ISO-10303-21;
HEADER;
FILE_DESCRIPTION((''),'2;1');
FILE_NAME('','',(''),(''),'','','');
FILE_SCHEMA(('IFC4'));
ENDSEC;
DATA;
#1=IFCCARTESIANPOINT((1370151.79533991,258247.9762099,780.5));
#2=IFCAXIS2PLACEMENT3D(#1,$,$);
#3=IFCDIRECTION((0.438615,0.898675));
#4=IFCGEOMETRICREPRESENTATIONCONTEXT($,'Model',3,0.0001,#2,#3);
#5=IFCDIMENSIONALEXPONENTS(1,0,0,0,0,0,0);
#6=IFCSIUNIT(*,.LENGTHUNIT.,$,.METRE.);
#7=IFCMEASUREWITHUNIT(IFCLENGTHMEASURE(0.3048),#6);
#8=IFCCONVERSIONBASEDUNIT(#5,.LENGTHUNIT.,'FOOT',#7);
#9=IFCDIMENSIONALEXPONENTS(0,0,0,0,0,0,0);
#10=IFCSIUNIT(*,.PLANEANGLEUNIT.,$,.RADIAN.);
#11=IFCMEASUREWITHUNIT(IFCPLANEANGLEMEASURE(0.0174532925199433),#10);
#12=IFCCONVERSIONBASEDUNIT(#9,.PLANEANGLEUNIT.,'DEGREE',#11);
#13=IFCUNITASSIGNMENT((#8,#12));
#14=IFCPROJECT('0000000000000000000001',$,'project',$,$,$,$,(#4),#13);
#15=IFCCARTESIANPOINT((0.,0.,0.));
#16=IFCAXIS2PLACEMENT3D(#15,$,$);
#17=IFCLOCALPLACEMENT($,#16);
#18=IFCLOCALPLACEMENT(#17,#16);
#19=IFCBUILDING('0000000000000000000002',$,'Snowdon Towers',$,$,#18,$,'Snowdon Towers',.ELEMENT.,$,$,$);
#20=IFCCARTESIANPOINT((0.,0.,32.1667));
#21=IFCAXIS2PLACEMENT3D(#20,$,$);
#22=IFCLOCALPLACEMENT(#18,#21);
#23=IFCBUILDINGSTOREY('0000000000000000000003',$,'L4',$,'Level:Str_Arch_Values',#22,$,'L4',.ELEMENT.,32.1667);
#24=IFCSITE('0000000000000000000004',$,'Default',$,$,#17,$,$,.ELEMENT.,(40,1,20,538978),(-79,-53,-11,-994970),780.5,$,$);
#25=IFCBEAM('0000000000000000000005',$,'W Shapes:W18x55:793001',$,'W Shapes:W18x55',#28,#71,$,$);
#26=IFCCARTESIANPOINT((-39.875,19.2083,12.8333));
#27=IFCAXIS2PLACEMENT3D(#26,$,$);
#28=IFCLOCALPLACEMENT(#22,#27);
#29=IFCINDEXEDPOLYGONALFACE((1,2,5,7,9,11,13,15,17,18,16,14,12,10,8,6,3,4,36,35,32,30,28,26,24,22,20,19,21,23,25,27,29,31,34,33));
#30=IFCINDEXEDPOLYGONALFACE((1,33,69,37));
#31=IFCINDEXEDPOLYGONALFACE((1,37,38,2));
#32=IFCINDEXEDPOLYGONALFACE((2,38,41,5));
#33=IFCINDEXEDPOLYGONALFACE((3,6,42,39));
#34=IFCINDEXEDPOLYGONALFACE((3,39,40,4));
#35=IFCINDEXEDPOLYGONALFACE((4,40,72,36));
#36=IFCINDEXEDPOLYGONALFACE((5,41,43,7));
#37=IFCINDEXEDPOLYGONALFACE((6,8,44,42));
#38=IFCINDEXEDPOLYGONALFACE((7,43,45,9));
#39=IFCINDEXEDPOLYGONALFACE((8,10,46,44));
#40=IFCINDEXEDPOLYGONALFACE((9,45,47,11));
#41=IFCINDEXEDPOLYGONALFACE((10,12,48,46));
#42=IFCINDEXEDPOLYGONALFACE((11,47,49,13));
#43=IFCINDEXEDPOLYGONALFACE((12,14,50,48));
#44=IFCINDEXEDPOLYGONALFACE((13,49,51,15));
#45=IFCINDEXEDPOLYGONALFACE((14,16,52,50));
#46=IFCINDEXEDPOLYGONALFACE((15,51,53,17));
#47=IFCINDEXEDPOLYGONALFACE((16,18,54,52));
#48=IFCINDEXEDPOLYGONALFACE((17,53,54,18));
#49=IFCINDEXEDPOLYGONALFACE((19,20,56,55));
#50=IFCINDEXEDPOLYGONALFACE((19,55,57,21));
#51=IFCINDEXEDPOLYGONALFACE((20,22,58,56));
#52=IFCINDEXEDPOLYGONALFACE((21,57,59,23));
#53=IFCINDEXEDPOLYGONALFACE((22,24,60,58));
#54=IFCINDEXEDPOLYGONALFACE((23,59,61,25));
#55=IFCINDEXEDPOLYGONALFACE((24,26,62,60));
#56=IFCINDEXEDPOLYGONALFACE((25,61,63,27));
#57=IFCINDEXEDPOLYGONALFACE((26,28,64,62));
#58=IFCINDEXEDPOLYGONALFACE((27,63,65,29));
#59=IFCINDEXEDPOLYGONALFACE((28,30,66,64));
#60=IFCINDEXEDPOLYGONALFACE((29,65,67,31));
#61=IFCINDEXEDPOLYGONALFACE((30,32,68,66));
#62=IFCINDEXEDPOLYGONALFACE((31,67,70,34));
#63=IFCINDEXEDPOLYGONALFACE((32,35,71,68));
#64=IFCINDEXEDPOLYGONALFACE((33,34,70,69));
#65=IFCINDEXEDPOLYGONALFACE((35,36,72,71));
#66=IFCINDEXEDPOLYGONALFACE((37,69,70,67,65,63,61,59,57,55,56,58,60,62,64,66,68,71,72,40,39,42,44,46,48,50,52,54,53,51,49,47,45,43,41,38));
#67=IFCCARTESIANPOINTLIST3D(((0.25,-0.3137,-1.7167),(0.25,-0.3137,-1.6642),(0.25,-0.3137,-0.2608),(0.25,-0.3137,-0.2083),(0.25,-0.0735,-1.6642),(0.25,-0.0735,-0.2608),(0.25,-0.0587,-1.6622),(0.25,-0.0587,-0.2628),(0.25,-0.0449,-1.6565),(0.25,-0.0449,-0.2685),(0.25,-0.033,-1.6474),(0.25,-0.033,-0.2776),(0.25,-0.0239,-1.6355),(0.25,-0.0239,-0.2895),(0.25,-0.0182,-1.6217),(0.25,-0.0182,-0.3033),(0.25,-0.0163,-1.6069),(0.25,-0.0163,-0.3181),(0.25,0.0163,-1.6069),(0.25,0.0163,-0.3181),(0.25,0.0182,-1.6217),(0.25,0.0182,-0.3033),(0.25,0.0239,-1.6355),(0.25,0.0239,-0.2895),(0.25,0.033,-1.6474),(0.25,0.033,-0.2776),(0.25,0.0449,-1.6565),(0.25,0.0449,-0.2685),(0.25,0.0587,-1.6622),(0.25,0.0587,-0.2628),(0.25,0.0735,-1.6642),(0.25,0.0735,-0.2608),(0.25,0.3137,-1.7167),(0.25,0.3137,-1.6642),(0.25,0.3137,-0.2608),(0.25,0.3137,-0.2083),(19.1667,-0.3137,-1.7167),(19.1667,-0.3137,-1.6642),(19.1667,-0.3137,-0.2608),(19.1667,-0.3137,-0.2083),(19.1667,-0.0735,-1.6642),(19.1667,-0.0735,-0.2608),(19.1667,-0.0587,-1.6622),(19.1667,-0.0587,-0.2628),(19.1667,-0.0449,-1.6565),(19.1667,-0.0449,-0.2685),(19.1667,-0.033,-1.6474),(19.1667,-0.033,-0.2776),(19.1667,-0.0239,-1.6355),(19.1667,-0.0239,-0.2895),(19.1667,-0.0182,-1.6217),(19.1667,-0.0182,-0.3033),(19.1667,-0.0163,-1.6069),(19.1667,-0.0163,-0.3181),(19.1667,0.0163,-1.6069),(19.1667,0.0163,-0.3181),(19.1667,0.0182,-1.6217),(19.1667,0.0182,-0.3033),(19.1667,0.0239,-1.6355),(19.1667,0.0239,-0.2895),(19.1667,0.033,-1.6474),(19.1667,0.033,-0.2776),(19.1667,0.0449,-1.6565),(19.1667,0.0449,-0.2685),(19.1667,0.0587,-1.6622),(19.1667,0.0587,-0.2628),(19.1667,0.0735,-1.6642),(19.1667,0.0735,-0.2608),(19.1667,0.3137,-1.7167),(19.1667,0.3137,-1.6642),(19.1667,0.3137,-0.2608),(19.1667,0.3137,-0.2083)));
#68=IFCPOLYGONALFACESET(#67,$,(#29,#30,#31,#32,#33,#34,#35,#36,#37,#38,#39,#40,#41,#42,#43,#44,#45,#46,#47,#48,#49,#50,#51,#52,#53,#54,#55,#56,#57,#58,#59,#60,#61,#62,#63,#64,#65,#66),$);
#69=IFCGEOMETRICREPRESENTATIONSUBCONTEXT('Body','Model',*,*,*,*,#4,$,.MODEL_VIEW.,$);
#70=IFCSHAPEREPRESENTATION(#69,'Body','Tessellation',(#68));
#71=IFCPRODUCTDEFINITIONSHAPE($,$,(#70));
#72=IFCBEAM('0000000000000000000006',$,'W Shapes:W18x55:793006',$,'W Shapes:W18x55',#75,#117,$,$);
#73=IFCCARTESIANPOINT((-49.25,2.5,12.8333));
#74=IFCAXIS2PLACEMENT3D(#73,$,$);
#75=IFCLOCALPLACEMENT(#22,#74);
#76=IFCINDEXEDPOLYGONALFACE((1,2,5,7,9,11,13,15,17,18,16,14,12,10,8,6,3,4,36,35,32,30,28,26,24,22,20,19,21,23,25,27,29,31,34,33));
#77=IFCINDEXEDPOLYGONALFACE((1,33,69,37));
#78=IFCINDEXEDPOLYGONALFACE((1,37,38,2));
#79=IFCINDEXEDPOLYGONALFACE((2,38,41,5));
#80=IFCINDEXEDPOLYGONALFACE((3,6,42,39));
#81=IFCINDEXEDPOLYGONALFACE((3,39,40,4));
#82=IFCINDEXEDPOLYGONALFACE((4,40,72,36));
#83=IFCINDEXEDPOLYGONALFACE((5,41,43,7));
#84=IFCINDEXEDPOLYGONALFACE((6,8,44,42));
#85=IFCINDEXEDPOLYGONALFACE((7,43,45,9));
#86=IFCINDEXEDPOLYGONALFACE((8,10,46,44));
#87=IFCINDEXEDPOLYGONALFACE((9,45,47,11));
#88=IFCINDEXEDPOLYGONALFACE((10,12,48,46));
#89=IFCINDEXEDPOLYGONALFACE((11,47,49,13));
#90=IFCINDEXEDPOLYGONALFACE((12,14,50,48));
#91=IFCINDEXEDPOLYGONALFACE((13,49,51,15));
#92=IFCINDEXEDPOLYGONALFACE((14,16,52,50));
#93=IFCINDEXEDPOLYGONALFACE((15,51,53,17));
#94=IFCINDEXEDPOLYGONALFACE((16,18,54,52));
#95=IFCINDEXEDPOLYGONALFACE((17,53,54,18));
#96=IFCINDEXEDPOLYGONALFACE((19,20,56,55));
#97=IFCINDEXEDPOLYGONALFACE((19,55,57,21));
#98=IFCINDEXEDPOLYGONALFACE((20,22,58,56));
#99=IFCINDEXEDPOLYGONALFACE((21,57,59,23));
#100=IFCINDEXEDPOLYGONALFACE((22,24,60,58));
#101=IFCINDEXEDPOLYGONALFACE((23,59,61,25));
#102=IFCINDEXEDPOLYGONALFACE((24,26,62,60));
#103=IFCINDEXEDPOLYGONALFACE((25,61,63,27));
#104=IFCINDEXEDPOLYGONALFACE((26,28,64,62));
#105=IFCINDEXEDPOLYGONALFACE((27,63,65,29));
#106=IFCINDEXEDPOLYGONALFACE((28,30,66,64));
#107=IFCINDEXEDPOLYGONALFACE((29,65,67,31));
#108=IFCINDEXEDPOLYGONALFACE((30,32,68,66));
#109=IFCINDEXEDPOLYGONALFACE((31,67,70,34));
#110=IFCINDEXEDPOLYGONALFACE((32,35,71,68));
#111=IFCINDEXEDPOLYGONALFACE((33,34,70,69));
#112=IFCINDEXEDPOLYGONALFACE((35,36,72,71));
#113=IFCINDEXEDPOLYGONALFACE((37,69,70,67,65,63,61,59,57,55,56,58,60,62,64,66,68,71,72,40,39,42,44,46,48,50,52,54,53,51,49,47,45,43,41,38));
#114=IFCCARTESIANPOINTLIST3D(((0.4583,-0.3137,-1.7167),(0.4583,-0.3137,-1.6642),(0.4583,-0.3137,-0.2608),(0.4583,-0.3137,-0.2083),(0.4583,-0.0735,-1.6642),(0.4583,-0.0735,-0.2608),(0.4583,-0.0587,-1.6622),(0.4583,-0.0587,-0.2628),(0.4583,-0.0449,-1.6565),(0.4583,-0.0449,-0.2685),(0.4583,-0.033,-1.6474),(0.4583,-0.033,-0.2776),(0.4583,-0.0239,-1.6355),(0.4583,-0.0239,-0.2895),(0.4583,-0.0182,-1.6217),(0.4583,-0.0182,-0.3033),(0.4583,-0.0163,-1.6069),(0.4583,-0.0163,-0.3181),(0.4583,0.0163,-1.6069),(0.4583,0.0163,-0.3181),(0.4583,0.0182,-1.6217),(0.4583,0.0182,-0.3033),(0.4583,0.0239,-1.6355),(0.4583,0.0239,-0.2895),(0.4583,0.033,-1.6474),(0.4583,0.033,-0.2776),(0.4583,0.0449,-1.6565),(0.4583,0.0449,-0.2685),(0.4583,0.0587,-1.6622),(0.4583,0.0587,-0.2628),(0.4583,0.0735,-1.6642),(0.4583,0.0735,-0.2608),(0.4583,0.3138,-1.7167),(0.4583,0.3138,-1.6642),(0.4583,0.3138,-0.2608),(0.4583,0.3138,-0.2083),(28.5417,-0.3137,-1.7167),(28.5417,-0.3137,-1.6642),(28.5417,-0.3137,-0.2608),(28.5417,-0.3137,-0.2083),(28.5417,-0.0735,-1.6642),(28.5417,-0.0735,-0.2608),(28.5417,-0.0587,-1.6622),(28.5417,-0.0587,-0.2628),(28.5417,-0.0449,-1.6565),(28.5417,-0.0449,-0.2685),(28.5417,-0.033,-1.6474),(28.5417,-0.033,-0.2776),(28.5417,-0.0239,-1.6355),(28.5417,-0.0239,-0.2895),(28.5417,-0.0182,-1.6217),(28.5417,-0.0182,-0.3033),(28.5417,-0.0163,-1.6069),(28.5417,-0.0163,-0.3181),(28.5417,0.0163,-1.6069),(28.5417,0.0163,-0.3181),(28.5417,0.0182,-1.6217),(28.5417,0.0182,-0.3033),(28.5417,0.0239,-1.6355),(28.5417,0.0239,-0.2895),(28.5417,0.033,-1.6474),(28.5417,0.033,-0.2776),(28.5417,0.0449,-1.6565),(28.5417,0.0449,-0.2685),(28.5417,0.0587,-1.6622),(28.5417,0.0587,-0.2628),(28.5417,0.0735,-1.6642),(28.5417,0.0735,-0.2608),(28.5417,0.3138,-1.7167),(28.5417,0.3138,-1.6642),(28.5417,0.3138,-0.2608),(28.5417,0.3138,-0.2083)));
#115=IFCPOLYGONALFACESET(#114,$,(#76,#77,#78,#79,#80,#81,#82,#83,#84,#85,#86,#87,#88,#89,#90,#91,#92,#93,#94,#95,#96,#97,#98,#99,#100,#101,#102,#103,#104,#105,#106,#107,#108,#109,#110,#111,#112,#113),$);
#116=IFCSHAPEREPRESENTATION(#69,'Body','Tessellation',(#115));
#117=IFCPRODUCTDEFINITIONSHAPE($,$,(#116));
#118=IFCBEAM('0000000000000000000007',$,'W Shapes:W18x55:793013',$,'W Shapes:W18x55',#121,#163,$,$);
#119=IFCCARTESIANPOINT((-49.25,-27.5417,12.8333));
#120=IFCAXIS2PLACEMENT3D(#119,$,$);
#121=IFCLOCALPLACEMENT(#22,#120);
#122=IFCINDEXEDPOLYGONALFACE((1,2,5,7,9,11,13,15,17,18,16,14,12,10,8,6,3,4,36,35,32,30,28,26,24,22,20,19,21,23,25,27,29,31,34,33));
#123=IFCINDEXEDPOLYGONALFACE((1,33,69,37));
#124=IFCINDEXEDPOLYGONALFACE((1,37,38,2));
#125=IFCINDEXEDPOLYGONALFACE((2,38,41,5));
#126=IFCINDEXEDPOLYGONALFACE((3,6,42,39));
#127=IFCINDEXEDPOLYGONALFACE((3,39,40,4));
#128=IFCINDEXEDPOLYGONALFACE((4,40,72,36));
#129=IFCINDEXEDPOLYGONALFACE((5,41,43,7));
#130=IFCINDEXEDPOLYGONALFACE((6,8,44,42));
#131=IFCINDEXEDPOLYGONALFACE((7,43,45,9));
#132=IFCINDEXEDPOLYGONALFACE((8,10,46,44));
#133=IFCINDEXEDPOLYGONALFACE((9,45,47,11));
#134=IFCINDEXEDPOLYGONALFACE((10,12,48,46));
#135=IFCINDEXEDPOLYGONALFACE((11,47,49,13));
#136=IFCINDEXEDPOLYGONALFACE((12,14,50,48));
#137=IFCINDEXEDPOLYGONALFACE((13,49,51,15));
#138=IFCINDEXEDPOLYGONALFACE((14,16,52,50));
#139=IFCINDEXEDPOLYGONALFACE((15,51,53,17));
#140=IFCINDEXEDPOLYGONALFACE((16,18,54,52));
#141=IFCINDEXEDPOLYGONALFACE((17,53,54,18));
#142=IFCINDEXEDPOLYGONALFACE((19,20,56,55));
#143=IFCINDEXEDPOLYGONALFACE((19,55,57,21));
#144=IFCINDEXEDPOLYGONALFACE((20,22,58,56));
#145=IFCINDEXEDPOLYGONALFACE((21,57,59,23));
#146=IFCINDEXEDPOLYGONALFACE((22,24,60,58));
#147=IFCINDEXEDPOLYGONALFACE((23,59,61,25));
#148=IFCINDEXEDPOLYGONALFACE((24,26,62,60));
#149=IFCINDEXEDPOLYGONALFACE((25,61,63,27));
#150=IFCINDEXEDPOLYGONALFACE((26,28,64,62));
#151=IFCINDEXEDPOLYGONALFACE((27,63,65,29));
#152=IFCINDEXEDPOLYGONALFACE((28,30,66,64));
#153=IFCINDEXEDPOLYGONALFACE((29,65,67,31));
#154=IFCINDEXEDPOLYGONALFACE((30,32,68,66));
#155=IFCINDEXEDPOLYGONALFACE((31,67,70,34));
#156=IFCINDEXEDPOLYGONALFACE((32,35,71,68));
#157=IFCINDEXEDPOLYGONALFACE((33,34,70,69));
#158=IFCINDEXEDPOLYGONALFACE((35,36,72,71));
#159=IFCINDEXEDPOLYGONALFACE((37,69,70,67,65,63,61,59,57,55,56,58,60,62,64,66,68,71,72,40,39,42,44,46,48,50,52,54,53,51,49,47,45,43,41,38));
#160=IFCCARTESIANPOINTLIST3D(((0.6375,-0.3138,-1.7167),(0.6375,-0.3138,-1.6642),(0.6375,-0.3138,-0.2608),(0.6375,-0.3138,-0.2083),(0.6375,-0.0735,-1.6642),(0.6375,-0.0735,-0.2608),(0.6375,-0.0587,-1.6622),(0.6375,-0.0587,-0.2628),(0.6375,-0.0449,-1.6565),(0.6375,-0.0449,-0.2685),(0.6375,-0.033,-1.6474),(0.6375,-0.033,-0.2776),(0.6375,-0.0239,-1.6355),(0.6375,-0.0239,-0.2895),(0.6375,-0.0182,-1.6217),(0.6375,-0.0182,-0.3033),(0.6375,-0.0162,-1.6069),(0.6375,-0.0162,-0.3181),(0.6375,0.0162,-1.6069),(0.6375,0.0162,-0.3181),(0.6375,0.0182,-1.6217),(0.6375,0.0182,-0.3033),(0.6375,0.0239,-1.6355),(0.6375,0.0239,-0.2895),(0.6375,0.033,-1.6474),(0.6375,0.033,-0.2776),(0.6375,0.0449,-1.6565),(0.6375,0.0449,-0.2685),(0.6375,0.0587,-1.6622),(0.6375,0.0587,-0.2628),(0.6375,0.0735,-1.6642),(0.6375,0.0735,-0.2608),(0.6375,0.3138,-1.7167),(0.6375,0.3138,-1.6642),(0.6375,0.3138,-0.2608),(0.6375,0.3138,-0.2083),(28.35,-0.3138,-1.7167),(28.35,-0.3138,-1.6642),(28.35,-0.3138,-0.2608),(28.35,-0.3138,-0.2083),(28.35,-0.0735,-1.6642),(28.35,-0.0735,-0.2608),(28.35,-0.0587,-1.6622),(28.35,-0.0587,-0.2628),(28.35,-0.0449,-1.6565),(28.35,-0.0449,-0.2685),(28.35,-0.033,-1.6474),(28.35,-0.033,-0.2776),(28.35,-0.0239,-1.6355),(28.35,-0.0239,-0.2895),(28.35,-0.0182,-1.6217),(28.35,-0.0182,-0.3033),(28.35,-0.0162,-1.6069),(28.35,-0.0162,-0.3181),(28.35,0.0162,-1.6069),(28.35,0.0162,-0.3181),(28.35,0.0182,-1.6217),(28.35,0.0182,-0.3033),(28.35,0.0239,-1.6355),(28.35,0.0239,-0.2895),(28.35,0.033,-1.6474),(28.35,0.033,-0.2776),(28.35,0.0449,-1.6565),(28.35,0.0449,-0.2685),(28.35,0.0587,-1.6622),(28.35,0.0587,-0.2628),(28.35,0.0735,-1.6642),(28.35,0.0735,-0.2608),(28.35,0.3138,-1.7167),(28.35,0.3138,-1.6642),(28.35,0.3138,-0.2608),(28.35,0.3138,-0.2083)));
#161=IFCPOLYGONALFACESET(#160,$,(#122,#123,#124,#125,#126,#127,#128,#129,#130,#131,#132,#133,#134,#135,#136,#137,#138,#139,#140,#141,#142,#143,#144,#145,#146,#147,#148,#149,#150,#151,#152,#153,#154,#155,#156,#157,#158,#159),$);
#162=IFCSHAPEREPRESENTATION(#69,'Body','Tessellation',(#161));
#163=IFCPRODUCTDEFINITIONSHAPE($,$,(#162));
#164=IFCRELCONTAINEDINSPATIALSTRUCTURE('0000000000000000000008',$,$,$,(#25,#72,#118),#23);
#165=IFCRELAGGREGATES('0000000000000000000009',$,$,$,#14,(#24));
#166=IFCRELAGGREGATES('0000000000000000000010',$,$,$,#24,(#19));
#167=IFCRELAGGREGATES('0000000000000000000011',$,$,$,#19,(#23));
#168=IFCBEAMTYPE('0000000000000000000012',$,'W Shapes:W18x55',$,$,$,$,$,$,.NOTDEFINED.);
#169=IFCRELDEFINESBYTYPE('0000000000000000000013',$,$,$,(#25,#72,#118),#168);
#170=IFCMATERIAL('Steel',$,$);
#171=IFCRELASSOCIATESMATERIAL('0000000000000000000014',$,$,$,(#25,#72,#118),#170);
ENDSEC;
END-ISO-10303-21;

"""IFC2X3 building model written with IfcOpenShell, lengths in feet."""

from ifc_helpers import new_model, entity, si_unit, converted_unit, direction, frame, frame_2d, origin, place, context, subcontext, project, spatial, i_section, extrude, material, type_object, element, save


model = new_model("IFC2X3")

# Units and contexts
model_context = context("Model", 3, precision=0.0001, world=frame((1370151.79533991, 258247.9762099, 780.5)), true_north=direction((0.438615, 0.898675)))
body_context = subcontext(model_context, "Body", "Model", "MODEL_VIEW")
ifc_project = project(units=[converted_unit("LENGTHUNIT", "FOOT", entity("IfcLengthMeasure", 0.3048), si_unit("LENGTHUNIT", "METRE"), dimensions=[1, 0, 0, 0, 0, 0, 0]), converted_unit("PLANEANGLEUNIT", "DEGREE", entity("IfcPlaneAngleMeasure", 0.0174532925199433), si_unit("PLANEANGLEUNIT", "RADIAN"), dimensions=[0, 0, 0, 0, 0, 0, 0])], contexts=[model_context])

# Site, building, storey
site_placement = place(None, origin())
site = spatial("IfcSite", under=ifc_project, at=site_placement, Name="Default", CompositionType="ELEMENT", RefLatitude=(40, 1, 20, 538978), RefLongitude=(-79, -53, -11, -994970), RefElevation=780.5)
building_placement = place(site_placement, origin())
building = spatial("IfcBuilding", under=site, at=building_placement, Name="Snowdon Towers", LongName="Snowdon Towers", CompositionType="ELEMENT")
storey_placement = place(building_placement, frame((0.0, 0.0, 32.1667)))
storey = spatial("IfcBuildingStorey", under=building, at=storey_placement, Name="L4", ObjectType="Level:Str_Arch_Values", LongName="L4", CompositionType="ELEMENT", Elevation=32.1667)

# Beams
ifc_material_1 = material(Name="Steel")
beam_type_1 = type_object("IfcBeamType", Name="W Shapes:W18x55", PredefinedType="NOTDEFINED")
beam_1_placement = place(storey_placement, frame((-39.875, 19.2083, 12.8333)))
element("IfcBeam", 1, at=beam_1_placement, inside=storey, type_object=beam_type_1, material=ifc_material_1, Name="W Shapes:W18x55:793001", ObjectType="W Shapes:W18x55", context=body_context, shape_type="SweptSolid", body=[
    extrude(i_section(OverallWidth=0.6275, OverallDepth=1.5083, WebThickness=0.0325, FlangeThickness=0.0525, FilletRadius=0.0573, at=frame_2d((0.0, 0.0), x_axis=(0.0, 1.0))), frame((0.25, 0.0, -0.9625), z_axis=(1.0, 0.0, 0.0), x_axis=(0.0, 0.0, -1.0)), (0.0, 0.0, 1.0), 18.9167),
])
beam_2_placement = place(storey_placement, frame((-49.25, 2.5, 12.8333)))
element("IfcBeam", 2, at=beam_2_placement, inside=storey, type_object=beam_type_1, material=ifc_material_1, Name="W Shapes:W18x55:793006", ObjectType="W Shapes:W18x55", context=body_context, shape_type="SweptSolid", body=[
    extrude(i_section(OverallWidth=0.6275, OverallDepth=1.5083, WebThickness=0.0325, FlangeThickness=0.0525, FilletRadius=0.0573, at=frame_2d((0.0, 0.0), x_axis=(0.0, 1.0))), frame((0.4583, 0.0, -0.9625), z_axis=(1.0, 0.0, 0.0), x_axis=(0.0, 0.0, -1.0)), (0.0, 0.0, 1.0), 28.0833),
])
beam_3_placement = place(storey_placement, frame((-49.25, -27.5417, 12.8333)))
element("IfcBeam", 3, at=beam_3_placement, inside=storey, type_object=beam_type_1, material=ifc_material_1, Name="W Shapes:W18x55:793013", ObjectType="W Shapes:W18x55", context=body_context, shape_type="SweptSolid", body=[
    extrude(i_section(OverallWidth=0.6275, OverallDepth=1.5083, WebThickness=0.0325, FlangeThickness=0.0525, FilletRadius=0.0573, at=frame_2d((0.0, 0.0), x_axis=(0.0, 1.0))), frame((0.6375, 0.0, -0.9625), z_axis=(1.0, 0.0, 0.0), x_axis=(0.0, 0.0, -1.0)), (0.0, 0.0, 1.0), 27.7125),
])

save(model, "model.ifc")
